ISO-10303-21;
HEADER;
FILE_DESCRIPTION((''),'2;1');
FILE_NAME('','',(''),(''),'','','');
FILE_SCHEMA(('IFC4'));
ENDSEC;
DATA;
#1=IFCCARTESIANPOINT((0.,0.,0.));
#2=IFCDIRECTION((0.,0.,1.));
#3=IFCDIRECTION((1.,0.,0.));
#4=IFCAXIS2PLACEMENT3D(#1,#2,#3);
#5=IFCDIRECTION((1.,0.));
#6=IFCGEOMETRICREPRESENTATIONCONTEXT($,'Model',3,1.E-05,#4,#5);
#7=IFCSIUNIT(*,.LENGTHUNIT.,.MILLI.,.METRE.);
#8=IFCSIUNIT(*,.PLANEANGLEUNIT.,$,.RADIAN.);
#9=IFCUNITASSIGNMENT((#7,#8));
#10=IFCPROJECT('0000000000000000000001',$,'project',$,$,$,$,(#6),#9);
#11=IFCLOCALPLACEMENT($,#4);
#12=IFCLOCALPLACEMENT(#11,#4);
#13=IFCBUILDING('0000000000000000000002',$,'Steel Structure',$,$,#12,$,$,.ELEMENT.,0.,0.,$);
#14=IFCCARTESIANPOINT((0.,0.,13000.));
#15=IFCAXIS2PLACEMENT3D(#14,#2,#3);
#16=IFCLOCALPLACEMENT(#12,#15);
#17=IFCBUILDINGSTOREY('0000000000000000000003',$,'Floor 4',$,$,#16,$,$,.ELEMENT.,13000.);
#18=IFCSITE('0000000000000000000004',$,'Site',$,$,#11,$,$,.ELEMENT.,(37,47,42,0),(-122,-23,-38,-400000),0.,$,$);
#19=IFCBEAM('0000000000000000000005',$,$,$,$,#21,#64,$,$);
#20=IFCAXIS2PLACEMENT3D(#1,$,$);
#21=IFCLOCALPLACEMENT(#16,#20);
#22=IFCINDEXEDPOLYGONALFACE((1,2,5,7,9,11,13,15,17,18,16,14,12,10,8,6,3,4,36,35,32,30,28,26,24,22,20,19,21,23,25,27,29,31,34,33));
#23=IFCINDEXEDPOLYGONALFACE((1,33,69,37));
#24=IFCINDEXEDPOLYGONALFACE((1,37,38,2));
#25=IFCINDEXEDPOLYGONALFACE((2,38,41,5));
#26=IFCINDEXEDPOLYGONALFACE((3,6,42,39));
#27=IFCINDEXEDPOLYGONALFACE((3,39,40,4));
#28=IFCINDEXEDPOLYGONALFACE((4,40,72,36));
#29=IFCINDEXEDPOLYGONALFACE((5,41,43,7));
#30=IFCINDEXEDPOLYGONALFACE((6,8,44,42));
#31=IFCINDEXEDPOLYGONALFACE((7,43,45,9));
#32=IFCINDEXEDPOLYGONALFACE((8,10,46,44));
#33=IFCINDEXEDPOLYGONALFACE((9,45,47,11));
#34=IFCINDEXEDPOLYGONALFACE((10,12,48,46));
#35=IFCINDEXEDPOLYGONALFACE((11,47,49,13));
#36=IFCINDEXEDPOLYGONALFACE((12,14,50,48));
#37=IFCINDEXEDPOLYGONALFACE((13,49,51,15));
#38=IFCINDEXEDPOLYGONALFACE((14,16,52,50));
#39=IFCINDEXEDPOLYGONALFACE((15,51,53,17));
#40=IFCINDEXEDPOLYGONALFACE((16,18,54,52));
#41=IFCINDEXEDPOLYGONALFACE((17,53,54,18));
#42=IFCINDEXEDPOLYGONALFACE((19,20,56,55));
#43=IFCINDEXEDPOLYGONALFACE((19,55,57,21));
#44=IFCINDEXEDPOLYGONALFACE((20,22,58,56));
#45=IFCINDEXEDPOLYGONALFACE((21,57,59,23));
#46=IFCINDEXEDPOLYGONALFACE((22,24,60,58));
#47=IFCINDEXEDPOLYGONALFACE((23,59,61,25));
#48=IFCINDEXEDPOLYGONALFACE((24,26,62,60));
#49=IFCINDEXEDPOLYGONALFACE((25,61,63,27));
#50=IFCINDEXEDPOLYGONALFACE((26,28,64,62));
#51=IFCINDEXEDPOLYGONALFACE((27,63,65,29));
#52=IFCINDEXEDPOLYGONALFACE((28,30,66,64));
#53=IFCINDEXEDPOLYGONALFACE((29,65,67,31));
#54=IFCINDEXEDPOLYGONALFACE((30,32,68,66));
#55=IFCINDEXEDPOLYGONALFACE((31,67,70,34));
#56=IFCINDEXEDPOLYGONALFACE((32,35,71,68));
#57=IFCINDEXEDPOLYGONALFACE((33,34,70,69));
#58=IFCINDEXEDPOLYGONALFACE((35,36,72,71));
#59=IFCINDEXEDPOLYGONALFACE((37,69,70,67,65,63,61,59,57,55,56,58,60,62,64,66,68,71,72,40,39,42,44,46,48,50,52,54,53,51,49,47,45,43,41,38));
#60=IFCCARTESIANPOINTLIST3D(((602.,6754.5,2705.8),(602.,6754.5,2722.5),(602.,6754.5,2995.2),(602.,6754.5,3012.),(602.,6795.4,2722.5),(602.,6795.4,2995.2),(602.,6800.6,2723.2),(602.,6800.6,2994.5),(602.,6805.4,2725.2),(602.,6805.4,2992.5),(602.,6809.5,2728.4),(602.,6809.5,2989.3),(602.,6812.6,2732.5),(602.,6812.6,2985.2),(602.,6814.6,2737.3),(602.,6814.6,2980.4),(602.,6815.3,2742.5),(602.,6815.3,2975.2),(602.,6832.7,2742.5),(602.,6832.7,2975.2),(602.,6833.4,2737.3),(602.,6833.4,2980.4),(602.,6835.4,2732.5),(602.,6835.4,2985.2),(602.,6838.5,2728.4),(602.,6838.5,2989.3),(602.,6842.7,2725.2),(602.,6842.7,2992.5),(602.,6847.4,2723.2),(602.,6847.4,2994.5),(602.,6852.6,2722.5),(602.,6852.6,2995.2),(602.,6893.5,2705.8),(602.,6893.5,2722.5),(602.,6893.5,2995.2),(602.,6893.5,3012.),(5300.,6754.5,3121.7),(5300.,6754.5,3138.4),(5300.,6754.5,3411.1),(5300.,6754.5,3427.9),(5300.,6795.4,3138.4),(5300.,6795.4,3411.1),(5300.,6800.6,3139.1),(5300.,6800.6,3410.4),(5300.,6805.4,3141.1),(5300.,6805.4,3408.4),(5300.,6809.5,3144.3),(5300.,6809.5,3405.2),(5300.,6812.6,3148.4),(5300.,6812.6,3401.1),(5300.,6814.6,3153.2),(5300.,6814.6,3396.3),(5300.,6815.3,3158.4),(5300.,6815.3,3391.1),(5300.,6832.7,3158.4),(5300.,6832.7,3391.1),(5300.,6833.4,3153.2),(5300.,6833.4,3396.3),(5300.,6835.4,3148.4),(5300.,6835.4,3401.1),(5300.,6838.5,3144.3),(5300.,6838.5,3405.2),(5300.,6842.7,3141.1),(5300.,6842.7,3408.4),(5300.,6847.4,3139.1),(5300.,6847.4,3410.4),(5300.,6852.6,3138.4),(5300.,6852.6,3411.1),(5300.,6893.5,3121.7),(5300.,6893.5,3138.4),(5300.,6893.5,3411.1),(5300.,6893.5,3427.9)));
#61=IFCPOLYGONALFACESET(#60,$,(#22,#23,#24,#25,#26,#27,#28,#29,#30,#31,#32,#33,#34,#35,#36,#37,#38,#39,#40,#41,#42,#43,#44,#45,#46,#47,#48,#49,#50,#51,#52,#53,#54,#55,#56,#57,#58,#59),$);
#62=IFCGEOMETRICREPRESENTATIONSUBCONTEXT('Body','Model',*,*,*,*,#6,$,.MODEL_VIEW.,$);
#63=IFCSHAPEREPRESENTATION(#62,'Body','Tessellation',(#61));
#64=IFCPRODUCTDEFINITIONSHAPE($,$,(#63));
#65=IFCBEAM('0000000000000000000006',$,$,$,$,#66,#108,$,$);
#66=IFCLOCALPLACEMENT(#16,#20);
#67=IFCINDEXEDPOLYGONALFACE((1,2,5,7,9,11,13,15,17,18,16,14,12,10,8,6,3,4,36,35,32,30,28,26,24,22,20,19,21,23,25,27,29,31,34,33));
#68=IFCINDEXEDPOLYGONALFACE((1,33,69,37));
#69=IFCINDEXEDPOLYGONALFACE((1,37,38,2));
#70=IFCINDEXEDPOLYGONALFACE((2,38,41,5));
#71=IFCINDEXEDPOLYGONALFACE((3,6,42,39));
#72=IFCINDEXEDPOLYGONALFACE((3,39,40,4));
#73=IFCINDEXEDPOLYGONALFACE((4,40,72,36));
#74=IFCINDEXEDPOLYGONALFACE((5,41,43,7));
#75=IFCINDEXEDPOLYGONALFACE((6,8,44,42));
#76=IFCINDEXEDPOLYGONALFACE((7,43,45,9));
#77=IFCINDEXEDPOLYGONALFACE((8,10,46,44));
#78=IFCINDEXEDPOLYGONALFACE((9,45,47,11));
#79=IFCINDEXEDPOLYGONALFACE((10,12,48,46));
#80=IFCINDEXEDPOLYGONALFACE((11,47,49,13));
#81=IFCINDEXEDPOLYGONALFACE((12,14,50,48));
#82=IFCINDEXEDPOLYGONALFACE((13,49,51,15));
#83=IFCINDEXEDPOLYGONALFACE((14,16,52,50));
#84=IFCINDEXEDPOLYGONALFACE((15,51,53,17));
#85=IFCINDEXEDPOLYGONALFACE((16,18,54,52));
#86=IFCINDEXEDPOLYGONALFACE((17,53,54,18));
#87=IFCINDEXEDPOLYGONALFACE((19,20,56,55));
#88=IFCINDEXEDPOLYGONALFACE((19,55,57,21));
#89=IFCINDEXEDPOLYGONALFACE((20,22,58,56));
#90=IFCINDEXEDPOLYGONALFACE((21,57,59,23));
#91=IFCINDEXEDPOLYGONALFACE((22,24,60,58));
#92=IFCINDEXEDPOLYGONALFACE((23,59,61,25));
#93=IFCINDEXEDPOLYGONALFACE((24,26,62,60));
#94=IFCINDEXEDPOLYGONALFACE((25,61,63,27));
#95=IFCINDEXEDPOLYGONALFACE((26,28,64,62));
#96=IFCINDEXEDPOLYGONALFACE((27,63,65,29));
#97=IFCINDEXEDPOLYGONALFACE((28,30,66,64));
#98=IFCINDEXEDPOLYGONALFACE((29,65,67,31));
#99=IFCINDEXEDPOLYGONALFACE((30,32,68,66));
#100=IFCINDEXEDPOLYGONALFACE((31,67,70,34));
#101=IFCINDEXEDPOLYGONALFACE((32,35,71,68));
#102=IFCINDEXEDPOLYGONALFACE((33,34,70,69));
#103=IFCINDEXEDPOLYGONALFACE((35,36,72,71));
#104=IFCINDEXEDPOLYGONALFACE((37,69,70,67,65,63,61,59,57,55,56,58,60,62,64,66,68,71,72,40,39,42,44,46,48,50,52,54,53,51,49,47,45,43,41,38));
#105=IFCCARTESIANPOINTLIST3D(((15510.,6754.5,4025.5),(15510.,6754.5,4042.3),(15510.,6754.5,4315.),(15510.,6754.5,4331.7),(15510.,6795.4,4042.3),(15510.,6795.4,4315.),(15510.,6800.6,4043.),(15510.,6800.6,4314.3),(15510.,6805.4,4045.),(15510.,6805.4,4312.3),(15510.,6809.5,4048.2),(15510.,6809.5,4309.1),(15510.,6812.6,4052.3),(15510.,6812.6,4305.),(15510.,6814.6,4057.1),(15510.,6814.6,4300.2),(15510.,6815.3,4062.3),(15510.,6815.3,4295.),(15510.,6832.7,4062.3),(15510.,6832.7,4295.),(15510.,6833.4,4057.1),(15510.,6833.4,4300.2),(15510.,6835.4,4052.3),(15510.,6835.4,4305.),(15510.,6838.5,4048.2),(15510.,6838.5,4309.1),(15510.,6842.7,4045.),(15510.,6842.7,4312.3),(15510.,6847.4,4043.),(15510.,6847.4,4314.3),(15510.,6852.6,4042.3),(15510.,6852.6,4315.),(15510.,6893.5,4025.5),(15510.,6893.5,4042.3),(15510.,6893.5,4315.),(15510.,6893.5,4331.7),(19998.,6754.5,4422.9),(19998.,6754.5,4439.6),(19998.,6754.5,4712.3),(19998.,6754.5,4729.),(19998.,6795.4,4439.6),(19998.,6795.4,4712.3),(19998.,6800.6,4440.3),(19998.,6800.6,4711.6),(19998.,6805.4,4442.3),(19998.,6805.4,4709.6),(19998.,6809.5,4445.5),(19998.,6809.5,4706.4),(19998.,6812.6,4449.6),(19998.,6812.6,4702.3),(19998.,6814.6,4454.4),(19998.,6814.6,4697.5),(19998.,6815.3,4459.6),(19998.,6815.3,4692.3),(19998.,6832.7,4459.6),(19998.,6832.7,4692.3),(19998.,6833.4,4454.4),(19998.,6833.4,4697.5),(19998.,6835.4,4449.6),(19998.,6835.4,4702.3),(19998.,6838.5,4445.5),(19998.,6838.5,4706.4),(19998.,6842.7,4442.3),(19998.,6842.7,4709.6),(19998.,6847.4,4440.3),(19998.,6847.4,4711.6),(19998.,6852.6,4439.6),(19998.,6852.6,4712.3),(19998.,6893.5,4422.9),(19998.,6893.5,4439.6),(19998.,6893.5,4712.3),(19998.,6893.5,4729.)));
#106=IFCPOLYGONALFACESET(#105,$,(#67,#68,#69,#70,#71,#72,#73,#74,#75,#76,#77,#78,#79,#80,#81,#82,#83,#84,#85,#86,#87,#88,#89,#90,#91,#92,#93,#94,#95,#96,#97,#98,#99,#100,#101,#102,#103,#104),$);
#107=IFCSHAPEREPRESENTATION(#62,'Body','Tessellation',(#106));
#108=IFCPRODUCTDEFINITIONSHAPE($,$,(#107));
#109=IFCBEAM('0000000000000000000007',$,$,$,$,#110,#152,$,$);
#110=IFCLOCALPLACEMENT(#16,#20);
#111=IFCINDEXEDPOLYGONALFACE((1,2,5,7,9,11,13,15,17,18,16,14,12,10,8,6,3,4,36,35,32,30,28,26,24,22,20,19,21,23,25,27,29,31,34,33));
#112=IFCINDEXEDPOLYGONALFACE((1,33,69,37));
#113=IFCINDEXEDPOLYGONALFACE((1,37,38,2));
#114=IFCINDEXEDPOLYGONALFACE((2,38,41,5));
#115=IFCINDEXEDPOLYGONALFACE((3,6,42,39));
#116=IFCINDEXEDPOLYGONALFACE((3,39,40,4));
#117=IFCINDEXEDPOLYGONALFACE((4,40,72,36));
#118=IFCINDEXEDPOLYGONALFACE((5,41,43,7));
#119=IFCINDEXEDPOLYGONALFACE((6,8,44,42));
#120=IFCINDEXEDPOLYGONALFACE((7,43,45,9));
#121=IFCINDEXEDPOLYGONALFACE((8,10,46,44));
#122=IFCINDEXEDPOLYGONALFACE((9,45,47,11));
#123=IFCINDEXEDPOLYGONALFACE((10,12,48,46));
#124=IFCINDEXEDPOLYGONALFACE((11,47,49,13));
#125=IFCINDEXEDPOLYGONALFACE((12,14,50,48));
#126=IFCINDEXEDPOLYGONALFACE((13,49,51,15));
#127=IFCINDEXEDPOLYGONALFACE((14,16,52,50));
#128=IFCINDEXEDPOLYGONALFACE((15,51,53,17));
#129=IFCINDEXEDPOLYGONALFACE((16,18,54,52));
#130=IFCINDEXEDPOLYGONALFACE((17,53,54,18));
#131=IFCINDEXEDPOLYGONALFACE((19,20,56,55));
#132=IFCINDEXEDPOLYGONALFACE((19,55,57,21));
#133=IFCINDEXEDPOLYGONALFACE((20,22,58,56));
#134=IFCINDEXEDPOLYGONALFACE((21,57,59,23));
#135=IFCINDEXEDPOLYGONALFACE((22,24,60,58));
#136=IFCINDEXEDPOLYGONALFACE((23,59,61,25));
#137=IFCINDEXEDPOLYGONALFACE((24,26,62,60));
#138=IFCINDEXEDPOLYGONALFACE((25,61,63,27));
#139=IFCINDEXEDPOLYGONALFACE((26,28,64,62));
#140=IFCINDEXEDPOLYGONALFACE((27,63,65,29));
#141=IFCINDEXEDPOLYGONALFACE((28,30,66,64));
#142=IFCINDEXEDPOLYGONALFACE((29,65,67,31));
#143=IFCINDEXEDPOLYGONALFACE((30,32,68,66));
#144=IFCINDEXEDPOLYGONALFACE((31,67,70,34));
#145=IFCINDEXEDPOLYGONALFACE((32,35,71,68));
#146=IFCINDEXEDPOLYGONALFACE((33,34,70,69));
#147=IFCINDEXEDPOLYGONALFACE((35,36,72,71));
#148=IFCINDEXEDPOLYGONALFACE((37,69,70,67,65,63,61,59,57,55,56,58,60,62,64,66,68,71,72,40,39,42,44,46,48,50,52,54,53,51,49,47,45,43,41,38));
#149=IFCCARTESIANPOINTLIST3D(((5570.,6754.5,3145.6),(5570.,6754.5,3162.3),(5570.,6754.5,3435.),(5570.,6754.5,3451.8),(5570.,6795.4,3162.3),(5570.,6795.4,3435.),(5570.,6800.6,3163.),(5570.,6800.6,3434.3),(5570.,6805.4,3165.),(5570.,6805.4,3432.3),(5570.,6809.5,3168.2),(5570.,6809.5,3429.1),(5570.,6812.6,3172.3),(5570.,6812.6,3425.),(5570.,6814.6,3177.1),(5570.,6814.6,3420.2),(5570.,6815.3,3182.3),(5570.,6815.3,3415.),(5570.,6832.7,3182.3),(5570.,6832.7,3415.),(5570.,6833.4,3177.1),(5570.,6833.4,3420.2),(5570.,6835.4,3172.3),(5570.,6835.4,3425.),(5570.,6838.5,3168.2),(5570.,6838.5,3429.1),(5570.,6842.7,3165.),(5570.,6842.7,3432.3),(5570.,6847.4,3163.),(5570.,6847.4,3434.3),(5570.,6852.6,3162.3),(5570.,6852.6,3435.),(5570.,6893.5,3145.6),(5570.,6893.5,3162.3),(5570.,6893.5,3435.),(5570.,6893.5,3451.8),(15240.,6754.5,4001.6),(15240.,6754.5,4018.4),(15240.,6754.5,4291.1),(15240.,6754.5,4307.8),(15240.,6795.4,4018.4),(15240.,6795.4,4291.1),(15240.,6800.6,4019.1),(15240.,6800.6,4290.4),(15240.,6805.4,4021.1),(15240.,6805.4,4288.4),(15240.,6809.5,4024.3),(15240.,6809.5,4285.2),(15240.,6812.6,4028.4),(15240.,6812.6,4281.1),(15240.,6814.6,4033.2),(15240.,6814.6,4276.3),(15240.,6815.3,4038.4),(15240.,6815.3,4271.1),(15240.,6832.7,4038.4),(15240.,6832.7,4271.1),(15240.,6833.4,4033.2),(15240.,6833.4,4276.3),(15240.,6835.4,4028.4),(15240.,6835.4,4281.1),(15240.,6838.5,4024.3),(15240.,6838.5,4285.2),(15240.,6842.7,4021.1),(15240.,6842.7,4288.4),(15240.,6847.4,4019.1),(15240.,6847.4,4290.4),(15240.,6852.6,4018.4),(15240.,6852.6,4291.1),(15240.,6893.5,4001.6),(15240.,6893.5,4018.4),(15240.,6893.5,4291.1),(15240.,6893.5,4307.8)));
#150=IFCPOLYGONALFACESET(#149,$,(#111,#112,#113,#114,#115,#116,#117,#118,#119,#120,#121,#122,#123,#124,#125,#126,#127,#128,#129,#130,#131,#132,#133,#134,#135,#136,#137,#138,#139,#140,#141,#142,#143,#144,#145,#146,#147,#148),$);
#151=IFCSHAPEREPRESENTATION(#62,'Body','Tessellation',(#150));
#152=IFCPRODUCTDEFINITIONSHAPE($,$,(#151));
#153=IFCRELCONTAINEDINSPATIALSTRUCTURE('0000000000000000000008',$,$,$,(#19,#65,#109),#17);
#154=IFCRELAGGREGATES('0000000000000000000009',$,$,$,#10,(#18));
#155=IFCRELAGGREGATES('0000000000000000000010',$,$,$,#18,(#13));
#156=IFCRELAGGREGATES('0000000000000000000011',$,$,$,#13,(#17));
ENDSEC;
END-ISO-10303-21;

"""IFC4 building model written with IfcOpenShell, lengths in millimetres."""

from ifc_helpers import new_model, si_unit, direction, frame, origin_with_axes, origin_2d_with_axis, place, context, subcontext, project, spatial, polyline, i_section, extrude, clip, bounded_halfspace, element, save


model = new_model("IFC4")

# Units and contexts
model_context = context("Model", 3, precision=1e-05, world=origin_with_axes(), true_north=direction((1.0, 0.0)))
body_context = subcontext(model_context, "Body", "Model", "MODEL_VIEW")
ifc_project = project(units=[si_unit("LENGTHUNIT", "METRE", prefix="MILLI"), si_unit("PLANEANGLEUNIT", "RADIAN")], contexts=[model_context])

# Site, building, storey
site_placement = place(None, origin_with_axes())
site = spatial("IfcSite", under=ifc_project, at=site_placement, Name="Site", CompositionType="ELEMENT", RefLatitude=(37, 47, 42, 0), RefLongitude=(-122, -23, -38, -400000), RefElevation=0.0)
building_placement = place(site_placement, origin_with_axes())
building = spatial("IfcBuilding", under=site, at=building_placement, Name="Steel Structure", CompositionType="ELEMENT", ElevationOfRefHeight=0.0, ElevationOfTerrain=0.0)
storey_placement = place(building_placement, frame((0.0, 0.0, 13000.0), z_axis=(0.0, 0.0, 1.0), x_axis=(1.0, 0.0, 0.0)))
storey = spatial("IfcBuildingStorey", under=building, at=storey_placement, Name="Floor 4", CompositionType="ELEMENT", Elevation=13000.0)

# Beams
beam_1_placement = place(storey_placement, frame((602.0, 6824.0, 2705.8), z_axis=(0.996104, 0.0, 0.088184), x_axis=(0.0, 1.0, 0.0)))
element("IfcBeam", 1, at=beam_1_placement, inside=storey, context=body_context, shape_type="Clipping", body=[
    clip(clip(extrude(i_section(OverallWidth=139.0, OverallDepth=305.0, WebThickness=17.4, FlangeThickness=16.7, FilletRadius=19.9, at=origin_2d_with_axis()), frame((0.0, 152.5, 0.0), z_axis=(0.0, 0.0, 1.0), x_axis=(1.0, 0.0, 0.0)), (0.0, 0.0, 1.0), 4743.4), bounded_halfspace(frame((-6824.0, -15644.6, -1385.0), z_axis=(0.0, 0.088184, -0.996104), x_axis=(-1.0, 0.0, 0.0)), False, frame((0.0, 152.5, 0.0), z_axis=(0.0, 0.0, 1.0), x_axis=(1.0, 0.0, 0.0)), polyline([(69.5, 152.5), (69.5, 135.8), (28.6, 135.8), (8.7, 115.9), (8.7, -115.9), (28.6, -135.8), (69.5, -135.8), (69.5, -152.5), (-69.5, -152.5), (-69.5, -135.8), (-28.6, -135.8), (-8.7, -115.9), (-8.7, 115.9), (-28.6, 135.8), (-69.5, 135.8), (-69.5, 152.5), (69.5, 152.5)]))), bounded_halfspace(frame((-6824.0, -16058.9, 3294.7), z_axis=(0.0, -0.088184, 0.996104), x_axis=(1.0, 0.0, 0.0)), False, frame((0.0, 152.5, 0.0), z_axis=(0.0, 0.0, 1.0), x_axis=(1.0, 0.0, 0.0)), polyline([(-69.5, -135.8), (-69.5, -152.5), (69.5, -152.5), (69.5, -135.8), (28.6, -135.8), (8.7, -115.9), (8.7, 115.9), (28.6, 135.8), (69.5, 135.8), (69.5, 152.5), (-69.5, 152.5), (-69.5, 135.8), (-28.6, 135.8), (-8.7, 115.9), (-8.7, -115.9), (-28.6, -135.8), (-69.5, -135.8)]))),
])
beam_2_placement = place(storey_placement, frame((15510.0, 6824.0, 4025.5), z_axis=(0.996104, 0.0, 0.088184), x_axis=(0.0, 1.0, 0.0)))
element("IfcBeam", 2, at=beam_2_placement, inside=storey, context=body_context, shape_type="Clipping", body=[
    clip(clip(extrude(i_section(OverallWidth=139.0, OverallDepth=305.0, WebThickness=17.4, FlangeThickness=16.7, FilletRadius=19.9, at=origin_2d_with_axis()), frame((0.0, 152.5, 0.0), z_axis=(0.0, 0.0, 1.0), x_axis=(1.0, 0.0, 0.0)), (0.0, 0.0, 1.0), 4532.6), bounded_halfspace(frame((-6824.0, -16959.2, -1501.4), z_axis=(0.0, 0.088184, -0.996104), x_axis=(-1.0, 0.0, 0.0)), False, frame((0.0, 152.5, 0.0), z_axis=(0.0, 0.0, 1.0), x_axis=(1.0, 0.0, 0.0)), polyline([(69.5, 152.5), (69.5, 135.8), (28.6, 135.8), (8.7, 115.9), (8.7, -115.9), (28.6, -135.8), (69.5, -135.8), (69.5, -152.5), (-69.5, -152.5), (-69.5, -135.8), (-28.6, -135.8), (-8.7, -115.9), (-8.7, 115.9), (-28.6, 135.8), (-69.5, 135.8), (-69.5, 152.5), (69.5, 152.5)]))), bounded_halfspace(frame((-6824.0, -17355.0, 2969.2), z_axis=(0.0, -0.088184, 0.996104), x_axis=(1.0, 0.0, 0.0)), False, frame((0.0, 152.5, 0.0), z_axis=(0.0, 0.0, 1.0), x_axis=(1.0, 0.0, 0.0)), polyline([(69.5, 135.8), (69.5, 152.5), (-69.5, 152.5), (-69.5, 135.8), (-28.6, 135.8), (-8.7, 115.9), (-8.7, -115.9), (-28.6, -135.8), (-69.5, -135.8), (-69.5, -152.5), (69.5, -152.5), (69.5, -135.8), (28.6, -135.8), (8.7, -115.9), (8.7, 115.9), (28.6, 135.8), (69.5, 135.8)]))),
])
beam_3_placement = place(storey_placement, frame((5570.0, 6824.0, 3145.6), z_axis=(0.996104, 0.0, 0.088184), x_axis=(0.0, 1.0, 0.0)))
element("IfcBeam", 3, at=beam_3_placement, inside=storey, context=body_context, shape_type="Clipping", body=[
    clip(clip(extrude(i_section(OverallWidth=139.0, OverallDepth=305.0, WebThickness=17.4, FlangeThickness=16.7, FilletRadius=19.9, at=origin_2d_with_axis()), frame((0.0, 152.5, 0.0), z_axis=(0.0, 0.0, 1.0), x_axis=(1.0, 0.0, 0.0)), (0.0, 0.0, 1.0), 9734.8), bounded_halfspace(frame((-6824.0, -16082.7, -1423.8), z_axis=(0.0, 0.088184, -0.996104), x_axis=(-1.0, 0.0, 0.0)), False, frame((0.0, 152.5, 0.0), z_axis=(0.0, 0.0, 1.0), x_axis=(1.0, 0.0, 0.0)), polyline([(69.5, 152.5), (69.5, 135.8), (28.6, 135.8), (8.7, 115.9), (8.7, -115.9), (28.6, -135.8), (69.5, -135.8), (69.5, -152.5), (-69.5, -152.5), (-69.5, -135.8), (-28.6, -135.8), (-8.7, -115.9), (-8.7, 115.9), (-28.6, 135.8), (-69.5, 135.8), (-69.5, 152.5), (69.5, 152.5)]))), bounded_halfspace(frame((-6824.0, -16935.4, 8208.5), z_axis=(0.0, -0.088184, 0.996104), x_axis=(1.0, 0.0, 0.0)), False, frame((0.0, 152.5, 0.0), z_axis=(0.0, 0.0, 1.0), x_axis=(1.0, 0.0, 0.0)), polyline([(-69.5, 152.5), (-69.5, 135.8), (-28.6, 135.8), (-8.7, 115.9), (-8.7, -115.9), (-28.6, -135.8), (-69.5, -135.8), (-69.5, -152.5), (69.5, -152.5), (69.5, -135.8), (28.6, -135.8), (8.7, -115.9), (8.7, 115.9), (28.6, 135.8), (69.5, 135.8), (69.5, 152.5), (-69.5, 152.5)]))),
])

save(model, "model.ifc")
